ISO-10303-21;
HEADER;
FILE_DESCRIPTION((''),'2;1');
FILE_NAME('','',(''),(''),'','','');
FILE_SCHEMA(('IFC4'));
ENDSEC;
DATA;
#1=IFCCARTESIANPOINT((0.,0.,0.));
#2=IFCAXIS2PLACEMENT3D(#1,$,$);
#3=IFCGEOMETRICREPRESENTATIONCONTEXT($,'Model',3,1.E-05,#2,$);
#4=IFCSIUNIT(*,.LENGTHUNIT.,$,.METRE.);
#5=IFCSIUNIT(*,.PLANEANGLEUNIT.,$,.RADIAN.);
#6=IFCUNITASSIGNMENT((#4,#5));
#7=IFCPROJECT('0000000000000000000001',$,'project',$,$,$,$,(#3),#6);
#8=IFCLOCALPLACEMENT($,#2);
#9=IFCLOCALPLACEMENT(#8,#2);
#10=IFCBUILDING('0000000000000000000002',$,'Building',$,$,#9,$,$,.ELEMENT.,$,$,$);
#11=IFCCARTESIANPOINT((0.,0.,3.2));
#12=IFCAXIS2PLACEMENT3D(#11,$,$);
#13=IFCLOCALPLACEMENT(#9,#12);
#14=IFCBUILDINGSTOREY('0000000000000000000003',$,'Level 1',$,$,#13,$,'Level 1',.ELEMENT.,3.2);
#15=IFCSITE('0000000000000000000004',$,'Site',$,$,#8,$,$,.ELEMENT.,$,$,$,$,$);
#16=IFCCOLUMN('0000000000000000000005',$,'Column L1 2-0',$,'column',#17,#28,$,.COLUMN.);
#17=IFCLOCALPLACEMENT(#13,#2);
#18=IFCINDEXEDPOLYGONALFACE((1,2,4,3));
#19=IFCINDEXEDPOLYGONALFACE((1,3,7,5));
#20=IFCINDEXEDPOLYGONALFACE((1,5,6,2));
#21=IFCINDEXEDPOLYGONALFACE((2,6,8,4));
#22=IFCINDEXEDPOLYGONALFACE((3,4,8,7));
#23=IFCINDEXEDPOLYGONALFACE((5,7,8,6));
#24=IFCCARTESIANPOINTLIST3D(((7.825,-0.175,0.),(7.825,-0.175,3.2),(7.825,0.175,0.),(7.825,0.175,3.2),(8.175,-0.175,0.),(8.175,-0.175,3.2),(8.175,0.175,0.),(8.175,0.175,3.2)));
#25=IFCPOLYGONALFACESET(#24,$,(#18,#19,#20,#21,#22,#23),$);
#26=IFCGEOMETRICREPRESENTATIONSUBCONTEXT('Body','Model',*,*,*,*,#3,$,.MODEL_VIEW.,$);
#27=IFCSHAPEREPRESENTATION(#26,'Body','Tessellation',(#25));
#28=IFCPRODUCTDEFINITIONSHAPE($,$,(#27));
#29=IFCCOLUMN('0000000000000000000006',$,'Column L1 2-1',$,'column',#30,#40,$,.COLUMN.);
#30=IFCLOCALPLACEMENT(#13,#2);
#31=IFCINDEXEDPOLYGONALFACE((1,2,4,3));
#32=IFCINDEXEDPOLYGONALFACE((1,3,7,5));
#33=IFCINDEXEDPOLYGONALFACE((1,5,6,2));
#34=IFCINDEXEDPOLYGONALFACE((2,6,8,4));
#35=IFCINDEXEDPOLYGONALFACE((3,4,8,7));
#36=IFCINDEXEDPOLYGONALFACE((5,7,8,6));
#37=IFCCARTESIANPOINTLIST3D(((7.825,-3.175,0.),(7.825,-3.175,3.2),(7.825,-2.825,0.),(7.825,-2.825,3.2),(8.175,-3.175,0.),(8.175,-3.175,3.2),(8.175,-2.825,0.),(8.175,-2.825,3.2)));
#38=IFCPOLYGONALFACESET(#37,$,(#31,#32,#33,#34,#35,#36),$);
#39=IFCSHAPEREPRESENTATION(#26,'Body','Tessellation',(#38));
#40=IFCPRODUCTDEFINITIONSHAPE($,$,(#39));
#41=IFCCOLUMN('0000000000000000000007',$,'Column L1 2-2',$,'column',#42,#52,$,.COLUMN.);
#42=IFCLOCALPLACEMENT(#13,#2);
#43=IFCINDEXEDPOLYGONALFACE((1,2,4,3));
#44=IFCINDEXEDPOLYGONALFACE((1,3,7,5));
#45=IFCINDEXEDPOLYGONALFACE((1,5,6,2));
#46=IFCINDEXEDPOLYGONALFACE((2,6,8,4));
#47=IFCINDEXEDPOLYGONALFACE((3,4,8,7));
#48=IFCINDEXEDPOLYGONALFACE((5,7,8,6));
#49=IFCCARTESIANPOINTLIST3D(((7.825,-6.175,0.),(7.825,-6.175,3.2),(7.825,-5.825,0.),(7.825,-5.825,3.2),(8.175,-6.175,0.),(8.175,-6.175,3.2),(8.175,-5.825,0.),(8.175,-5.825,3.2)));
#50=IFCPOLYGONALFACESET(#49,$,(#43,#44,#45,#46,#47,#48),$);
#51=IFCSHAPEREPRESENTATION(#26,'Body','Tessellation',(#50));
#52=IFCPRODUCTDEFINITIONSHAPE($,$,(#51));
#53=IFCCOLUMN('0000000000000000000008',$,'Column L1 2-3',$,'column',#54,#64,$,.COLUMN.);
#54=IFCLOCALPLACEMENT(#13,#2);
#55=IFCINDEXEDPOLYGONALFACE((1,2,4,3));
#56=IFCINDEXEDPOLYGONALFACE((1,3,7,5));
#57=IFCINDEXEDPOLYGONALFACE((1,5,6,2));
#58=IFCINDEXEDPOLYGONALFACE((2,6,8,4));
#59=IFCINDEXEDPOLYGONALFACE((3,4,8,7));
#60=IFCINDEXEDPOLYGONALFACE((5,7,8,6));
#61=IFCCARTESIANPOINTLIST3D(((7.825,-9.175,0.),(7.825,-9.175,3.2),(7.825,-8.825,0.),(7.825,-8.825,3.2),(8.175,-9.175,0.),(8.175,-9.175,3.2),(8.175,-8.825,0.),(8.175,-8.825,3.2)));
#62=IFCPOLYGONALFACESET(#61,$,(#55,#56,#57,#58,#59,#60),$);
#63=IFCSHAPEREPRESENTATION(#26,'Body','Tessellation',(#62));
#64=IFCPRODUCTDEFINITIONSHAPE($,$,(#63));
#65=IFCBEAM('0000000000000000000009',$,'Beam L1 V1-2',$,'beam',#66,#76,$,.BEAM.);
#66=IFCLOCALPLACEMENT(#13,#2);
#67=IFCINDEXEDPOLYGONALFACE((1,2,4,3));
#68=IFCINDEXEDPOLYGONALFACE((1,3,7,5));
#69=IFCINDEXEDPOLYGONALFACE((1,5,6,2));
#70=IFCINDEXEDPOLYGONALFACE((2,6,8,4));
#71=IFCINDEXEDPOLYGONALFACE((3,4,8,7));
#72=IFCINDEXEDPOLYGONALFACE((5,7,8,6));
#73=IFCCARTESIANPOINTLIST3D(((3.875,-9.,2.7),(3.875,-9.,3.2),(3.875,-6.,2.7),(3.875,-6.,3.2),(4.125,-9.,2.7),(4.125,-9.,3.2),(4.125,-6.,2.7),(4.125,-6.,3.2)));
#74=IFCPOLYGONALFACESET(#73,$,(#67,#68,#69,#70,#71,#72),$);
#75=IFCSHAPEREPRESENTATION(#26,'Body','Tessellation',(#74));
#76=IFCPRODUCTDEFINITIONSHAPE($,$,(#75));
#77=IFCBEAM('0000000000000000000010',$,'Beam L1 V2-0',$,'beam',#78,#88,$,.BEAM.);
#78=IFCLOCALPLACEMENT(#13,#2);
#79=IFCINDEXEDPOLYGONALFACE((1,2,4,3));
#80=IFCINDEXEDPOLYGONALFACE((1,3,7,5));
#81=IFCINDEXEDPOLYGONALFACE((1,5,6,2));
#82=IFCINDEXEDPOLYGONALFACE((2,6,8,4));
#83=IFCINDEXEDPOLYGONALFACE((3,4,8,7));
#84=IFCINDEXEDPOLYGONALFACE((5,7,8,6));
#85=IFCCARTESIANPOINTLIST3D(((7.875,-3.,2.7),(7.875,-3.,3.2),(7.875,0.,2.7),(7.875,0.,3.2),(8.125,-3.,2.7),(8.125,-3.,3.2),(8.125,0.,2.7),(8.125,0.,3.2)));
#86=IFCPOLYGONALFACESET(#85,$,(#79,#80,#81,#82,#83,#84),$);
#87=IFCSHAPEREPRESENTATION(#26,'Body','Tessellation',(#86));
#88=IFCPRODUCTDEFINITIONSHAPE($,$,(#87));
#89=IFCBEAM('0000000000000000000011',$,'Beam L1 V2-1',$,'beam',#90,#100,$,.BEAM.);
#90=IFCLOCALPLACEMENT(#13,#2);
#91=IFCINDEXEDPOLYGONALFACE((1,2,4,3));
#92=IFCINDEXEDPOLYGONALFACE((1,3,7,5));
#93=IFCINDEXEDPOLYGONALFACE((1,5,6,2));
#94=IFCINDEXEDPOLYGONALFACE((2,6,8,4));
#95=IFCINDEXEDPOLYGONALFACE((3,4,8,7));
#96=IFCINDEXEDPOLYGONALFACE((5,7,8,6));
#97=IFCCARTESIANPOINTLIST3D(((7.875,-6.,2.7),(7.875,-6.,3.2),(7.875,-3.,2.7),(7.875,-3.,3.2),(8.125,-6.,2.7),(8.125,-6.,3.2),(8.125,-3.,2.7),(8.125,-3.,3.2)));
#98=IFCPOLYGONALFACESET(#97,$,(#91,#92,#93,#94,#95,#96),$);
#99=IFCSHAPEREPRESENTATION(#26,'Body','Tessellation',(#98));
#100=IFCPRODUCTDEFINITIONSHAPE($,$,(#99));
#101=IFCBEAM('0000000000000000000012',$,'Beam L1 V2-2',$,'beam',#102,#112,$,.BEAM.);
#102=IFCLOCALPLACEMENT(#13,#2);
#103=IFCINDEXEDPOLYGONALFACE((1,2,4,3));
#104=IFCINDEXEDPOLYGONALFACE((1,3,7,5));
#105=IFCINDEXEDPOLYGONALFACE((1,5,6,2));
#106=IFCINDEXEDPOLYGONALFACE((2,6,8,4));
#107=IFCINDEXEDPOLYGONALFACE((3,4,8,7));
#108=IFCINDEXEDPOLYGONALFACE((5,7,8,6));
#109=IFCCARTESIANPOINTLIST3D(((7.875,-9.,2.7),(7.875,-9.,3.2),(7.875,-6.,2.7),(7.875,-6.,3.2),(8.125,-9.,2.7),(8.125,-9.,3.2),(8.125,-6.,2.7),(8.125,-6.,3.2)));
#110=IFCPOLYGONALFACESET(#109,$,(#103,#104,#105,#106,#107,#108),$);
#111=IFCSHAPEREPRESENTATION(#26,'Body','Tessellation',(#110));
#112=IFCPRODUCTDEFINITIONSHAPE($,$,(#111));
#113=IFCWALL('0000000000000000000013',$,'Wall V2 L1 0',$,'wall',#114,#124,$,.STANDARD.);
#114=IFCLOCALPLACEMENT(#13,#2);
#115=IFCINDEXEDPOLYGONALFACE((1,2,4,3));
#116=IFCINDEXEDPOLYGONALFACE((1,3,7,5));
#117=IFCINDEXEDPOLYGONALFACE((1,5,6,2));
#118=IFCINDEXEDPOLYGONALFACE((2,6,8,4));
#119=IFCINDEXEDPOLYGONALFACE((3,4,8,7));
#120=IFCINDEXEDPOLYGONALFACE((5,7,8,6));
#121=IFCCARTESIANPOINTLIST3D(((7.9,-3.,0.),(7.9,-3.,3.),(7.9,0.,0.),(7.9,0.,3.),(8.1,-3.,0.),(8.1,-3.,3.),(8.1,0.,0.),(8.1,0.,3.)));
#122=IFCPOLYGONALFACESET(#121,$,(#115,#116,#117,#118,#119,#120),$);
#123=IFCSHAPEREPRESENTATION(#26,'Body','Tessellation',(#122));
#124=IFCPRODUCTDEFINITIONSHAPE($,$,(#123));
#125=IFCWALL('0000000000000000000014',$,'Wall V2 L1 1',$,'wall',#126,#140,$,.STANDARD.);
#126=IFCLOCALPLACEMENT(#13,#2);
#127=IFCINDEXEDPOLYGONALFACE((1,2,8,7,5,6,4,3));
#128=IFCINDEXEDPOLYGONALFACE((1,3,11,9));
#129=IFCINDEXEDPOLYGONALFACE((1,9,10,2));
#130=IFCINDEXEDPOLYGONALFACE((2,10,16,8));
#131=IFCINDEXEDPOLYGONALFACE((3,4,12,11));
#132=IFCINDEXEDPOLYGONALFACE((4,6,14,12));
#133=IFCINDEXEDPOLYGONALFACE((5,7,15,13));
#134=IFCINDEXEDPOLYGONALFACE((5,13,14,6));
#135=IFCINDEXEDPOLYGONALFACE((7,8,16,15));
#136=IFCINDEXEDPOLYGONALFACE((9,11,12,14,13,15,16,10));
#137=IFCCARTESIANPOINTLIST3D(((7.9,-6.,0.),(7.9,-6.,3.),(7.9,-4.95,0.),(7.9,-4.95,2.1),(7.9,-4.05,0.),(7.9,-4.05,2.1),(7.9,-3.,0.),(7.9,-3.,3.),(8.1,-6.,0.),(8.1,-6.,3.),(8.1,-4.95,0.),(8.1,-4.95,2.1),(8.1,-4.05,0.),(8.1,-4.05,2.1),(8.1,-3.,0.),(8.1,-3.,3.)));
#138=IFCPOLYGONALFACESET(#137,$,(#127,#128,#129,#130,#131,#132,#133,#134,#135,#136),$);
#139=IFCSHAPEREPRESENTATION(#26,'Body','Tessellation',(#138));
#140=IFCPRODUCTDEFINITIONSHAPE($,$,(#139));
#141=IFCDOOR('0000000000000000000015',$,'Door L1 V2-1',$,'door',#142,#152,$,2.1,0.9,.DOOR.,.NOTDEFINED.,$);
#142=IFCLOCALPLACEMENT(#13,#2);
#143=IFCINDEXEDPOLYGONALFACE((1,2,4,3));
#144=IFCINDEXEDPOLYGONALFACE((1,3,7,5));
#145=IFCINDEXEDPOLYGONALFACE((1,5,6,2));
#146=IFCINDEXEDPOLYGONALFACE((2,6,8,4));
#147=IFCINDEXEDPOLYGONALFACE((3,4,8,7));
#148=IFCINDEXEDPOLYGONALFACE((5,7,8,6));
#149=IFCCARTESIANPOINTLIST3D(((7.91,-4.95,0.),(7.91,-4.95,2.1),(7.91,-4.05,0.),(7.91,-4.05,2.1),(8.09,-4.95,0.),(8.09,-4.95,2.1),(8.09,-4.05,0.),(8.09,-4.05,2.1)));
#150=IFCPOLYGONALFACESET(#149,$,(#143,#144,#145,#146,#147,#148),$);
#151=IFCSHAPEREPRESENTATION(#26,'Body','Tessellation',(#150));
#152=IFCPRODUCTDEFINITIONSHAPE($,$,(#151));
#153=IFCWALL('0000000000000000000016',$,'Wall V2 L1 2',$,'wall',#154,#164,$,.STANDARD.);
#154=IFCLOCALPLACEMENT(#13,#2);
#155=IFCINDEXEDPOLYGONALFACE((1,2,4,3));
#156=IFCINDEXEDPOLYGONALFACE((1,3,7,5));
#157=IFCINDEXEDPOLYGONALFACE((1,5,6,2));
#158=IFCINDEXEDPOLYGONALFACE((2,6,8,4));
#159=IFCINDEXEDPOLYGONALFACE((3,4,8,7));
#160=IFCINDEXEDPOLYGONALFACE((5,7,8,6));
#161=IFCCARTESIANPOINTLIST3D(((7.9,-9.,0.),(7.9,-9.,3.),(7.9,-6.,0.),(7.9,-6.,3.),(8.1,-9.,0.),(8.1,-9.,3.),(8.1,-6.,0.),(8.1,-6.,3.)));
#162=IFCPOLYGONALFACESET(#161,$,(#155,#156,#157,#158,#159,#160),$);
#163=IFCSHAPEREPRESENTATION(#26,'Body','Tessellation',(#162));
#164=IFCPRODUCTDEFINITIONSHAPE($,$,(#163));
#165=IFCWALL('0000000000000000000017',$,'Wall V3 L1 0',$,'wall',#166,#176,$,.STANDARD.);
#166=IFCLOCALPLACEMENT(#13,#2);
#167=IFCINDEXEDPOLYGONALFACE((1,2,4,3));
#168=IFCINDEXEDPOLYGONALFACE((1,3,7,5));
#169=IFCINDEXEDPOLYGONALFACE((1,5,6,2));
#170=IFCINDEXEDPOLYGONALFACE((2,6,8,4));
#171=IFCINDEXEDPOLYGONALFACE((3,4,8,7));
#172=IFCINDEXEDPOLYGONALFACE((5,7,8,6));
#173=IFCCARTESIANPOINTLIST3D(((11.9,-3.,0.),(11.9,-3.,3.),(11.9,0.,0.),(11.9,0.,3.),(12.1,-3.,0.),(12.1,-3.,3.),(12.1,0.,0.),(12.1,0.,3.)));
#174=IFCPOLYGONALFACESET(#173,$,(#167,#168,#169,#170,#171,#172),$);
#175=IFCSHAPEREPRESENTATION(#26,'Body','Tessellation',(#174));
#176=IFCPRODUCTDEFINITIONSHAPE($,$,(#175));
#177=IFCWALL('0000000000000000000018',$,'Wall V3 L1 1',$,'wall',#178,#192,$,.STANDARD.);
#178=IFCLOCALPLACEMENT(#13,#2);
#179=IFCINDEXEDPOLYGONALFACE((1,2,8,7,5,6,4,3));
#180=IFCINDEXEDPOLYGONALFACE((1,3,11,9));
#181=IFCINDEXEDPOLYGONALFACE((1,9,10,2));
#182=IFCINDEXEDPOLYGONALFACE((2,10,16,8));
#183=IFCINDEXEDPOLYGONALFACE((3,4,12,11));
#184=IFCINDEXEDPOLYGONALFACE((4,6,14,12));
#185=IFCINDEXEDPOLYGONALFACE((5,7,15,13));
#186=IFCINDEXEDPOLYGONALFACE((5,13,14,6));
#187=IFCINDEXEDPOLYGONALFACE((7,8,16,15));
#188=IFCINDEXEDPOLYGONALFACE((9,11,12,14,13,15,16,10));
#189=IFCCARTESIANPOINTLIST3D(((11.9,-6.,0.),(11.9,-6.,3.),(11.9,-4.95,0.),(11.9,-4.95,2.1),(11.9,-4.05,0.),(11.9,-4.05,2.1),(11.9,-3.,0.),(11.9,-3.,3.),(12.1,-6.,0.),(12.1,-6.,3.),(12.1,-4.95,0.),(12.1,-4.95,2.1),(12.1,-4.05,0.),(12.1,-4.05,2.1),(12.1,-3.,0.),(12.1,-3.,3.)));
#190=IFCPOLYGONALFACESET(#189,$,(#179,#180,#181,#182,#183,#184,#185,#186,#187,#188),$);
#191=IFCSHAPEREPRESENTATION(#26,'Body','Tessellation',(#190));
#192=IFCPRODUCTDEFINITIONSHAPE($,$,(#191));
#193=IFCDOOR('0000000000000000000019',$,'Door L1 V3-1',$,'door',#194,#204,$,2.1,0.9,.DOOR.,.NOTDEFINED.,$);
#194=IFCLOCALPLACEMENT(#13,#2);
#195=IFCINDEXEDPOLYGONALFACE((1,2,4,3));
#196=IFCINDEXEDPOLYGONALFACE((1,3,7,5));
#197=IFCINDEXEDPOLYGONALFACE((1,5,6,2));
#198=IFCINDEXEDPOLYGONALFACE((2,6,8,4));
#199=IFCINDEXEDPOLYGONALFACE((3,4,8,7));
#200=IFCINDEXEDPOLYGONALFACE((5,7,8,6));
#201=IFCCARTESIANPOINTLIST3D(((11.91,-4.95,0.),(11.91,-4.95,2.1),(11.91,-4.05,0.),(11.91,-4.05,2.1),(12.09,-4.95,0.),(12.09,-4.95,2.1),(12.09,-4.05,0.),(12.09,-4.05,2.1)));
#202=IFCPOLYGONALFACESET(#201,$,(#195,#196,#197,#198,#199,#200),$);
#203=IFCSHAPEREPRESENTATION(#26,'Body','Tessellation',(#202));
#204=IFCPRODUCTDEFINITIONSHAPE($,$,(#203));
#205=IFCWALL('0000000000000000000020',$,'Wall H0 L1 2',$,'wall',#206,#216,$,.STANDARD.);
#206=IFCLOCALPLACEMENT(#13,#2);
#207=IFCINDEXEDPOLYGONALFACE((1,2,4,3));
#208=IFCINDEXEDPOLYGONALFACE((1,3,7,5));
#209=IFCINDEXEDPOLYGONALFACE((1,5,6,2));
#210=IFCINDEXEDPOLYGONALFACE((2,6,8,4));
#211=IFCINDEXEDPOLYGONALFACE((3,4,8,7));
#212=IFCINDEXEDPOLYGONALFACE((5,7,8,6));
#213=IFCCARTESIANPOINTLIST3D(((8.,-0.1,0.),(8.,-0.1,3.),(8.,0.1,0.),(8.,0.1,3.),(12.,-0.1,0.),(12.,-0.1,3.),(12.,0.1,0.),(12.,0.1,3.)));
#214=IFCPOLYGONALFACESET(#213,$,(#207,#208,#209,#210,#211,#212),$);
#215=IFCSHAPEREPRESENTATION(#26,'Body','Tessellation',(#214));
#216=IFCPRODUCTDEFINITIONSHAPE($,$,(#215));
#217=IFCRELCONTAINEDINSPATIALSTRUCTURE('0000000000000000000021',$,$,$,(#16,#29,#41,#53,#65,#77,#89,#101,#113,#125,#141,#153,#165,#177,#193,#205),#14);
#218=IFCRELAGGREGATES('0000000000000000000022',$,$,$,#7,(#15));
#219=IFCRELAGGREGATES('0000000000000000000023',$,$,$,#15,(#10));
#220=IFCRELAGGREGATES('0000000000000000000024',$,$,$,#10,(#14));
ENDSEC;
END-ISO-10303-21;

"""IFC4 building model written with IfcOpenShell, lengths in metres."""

from ifc_helpers import new_model, si_unit, frame, frame_2d, origin, origin_2d, place, context, subcontext, project, spatial, rectangle, extrude, element, fill, save


model = new_model("IFC4")

# Units and contexts
model_context = context("Model", 3, precision=1e-05, world=origin())
body_context = subcontext(model_context, "Body", "Model", "MODEL_VIEW")
ifc_project = project(units=[si_unit("LENGTHUNIT", "METRE"), si_unit("PLANEANGLEUNIT", "RADIAN")], contexts=[model_context])

# Site, building, storey
site_placement = place(None, origin())
site = spatial("IfcSite", under=ifc_project, at=site_placement, Name="Site", CompositionType="ELEMENT")
building_placement = place(site_placement, origin())
building = spatial("IfcBuilding", under=site, at=building_placement, Name="Building", CompositionType="ELEMENT")
storey_placement = place(building_placement, frame((0.0, 0.0, 3.2)))
storey = spatial("IfcBuildingStorey", under=building, at=storey_placement, Name="Level 1", LongName="Level 1", CompositionType="ELEMENT", Elevation=3.2)

# Columns
for number, where, name in (
    (1, (8.0, 0.0, 0.0), "Column L1 2-0"),
    (2, (8.0, -3.0, 0.0), "Column L1 2-1"),
    (3, (8.0, -6.0, 0.0), "Column L1 2-2"),
    (4, (8.0, -9.0, 0.0), "Column L1 2-3"),
):
    element("IfcColumn", number, at=place(storey_placement, frame(where)), inside=storey, Name=name, ObjectType="column", PredefinedType="COLUMN", context=body_context, shape_type="SweptSolid", body=[
        extrude(rectangle(XDim=0.35, YDim=0.35, at=origin_2d()), origin(), (0.0, 0.0, 1.0), 3.2),
    ])

# Beams
for number, where, z_axis, x_axis, name in (
    (5, (4.0, -6.0, 2.95), (0.0, -1.0, 0.0), (0.0, 0.0, 1.0), "Beam L1 V1-2"),
    (6, (8.0, 0.0, 2.95), (0.0, -1.0, 0.0), (0.0, 0.0, 1.0), "Beam L1 V2-0"),
    (7, (8.0, -3.0, 2.95), (0.0, -1.0, 0.0), (0.0, 0.0, 1.0), "Beam L1 V2-1"),
    (8, (8.0, -6.0, 2.95), (0.0, -1.0, 0.0), (0.0, 0.0, 1.0), "Beam L1 V2-2"),
):
    element("IfcBeam", number, at=place(storey_placement, frame(where, z_axis=z_axis, x_axis=x_axis)), inside=storey, Name=name, ObjectType="beam", PredefinedType="BEAM", context=body_context, shape_type="SweptSolid", body=[
        extrude(rectangle(XDim=0.5, YDim=0.25, at=origin_2d()), origin(), (0.0, 0.0, 1.0), 3.0),
    ])

# Wall
wall_1_placement = place(storey_placement, frame((8.0, 0.0, 0.0), z_axis=(0.0, 0.0, 1.0), x_axis=(0.0, -1.0, 0.0)))
element("IfcWall", 9, at=wall_1_placement, inside=storey, Name="Wall V2 L1 0", ObjectType="wall", PredefinedType="STANDARD", context=body_context, shape_type="SweptSolid", body=[
    extrude(rectangle(XDim=3.0, YDim=0.2, at=frame_2d((1.5, 0.0))), origin(), (0.0, 0.0, 1.0), 3.0),
])

# Wall, opening, door
wall_2_placement = place(storey_placement, frame((8.0, -3.0, 0.0), z_axis=(0.0, 0.0, 1.0), x_axis=(0.0, -1.0, 0.0)))
wall_2 = element("IfcWall", 10, at=wall_2_placement, inside=storey, Name="Wall V2 L1 1", ObjectType="wall", PredefinedType="STANDARD", context=body_context, shape_type="SweptSolid", body=[
    extrude(rectangle(XDim=3.0, YDim=0.2, at=frame_2d((1.5, 0.0))), origin(), (0.0, 0.0, 1.0), 3.0),
])
opening_1_placement = place(storey_placement, frame((8.0, -4.5, 0.0), z_axis=(0.0, 0.0, 1.0), x_axis=(0.0, -1.0, 0.0)))
opening_1 = element("IfcOpeningElement", 11, at=opening_1_placement, cuts=wall_2, ObjectType="Opening", PredefinedType="OPENING", context=body_context, shape_type="SweptSolid", body=[
    extrude(rectangle(XDim=0.9, YDim=0.22, at=origin_2d()), origin(), (0.0, 0.0, 1.0), 2.1),
])
door_1_placement = place(storey_placement, frame((8.0, -4.5, 0.0), z_axis=(0.0, 0.0, 1.0), x_axis=(0.0, -1.0, 0.0)))
door_1 = element("IfcDoor", 12, at=door_1_placement, inside=storey, Name="Door L1 V2-1", ObjectType="door", OperationType="NOTDEFINED", OverallHeight=2.1, OverallWidth=0.9, PredefinedType="DOOR", context=body_context, shape_type="SweptSolid", body=[
    extrude(rectangle(XDim=0.9, YDim=0.18, at=origin_2d()), origin(), (0.0, 0.0, 1.0), 2.1),
])
fill(opening_1, door_1)

# Walls
for number, where, z_axis, x_axis, name in (
    (13, (8.0, -6.0, 0.0), (0.0, 0.0, 1.0), (0.0, -1.0, 0.0), "Wall V2 L1 2"),
    (14, (12.0, 0.0, 0.0), (0.0, 0.0, 1.0), (0.0, -1.0, 0.0), "Wall V3 L1 0"),
):
    element("IfcWall", number, at=place(storey_placement, frame(where, z_axis=z_axis, x_axis=x_axis)), inside=storey, Name=name, ObjectType="wall", PredefinedType="STANDARD", context=body_context, shape_type="SweptSolid", body=[
        extrude(rectangle(XDim=3.0, YDim=0.2, at=frame_2d((1.5, 0.0))), origin(), (0.0, 0.0, 1.0), 3.0),
    ])

# Wall, opening, door
wall_3_placement = place(storey_placement, frame((12.0, -3.0, 0.0), z_axis=(0.0, 0.0, 1.0), x_axis=(0.0, -1.0, 0.0)))
wall_3 = element("IfcWall", 15, at=wall_3_placement, inside=storey, Name="Wall V3 L1 1", ObjectType="wall", PredefinedType="STANDARD", context=body_context, shape_type="SweptSolid", body=[
    extrude(rectangle(XDim=3.0, YDim=0.2, at=frame_2d((1.5, 0.0))), origin(), (0.0, 0.0, 1.0), 3.0),
])
opening_2_placement = place(storey_placement, frame((12.0, -4.5, 0.0), z_axis=(0.0, 0.0, 1.0), x_axis=(0.0, -1.0, 0.0)))
opening_2 = element("IfcOpeningElement", 16, at=opening_2_placement, cuts=wall_3, ObjectType="Opening", PredefinedType="OPENING", context=body_context, shape_type="SweptSolid", body=[
    extrude(rectangle(XDim=0.9, YDim=0.22, at=origin_2d()), origin(), (0.0, 0.0, 1.0), 2.1),
])
door_2_placement = place(storey_placement, frame((12.0, -4.5, 0.0), z_axis=(0.0, 0.0, 1.0), x_axis=(0.0, -1.0, 0.0)))
door_2 = element("IfcDoor", 17, at=door_2_placement, inside=storey, Name="Door L1 V3-1", ObjectType="door", OperationType="NOTDEFINED", OverallHeight=2.1, OverallWidth=0.9, PredefinedType="DOOR", context=body_context, shape_type="SweptSolid", body=[
    extrude(rectangle(XDim=0.9, YDim=0.18, at=origin_2d()), origin(), (0.0, 0.0, 1.0), 2.1),
])
fill(opening_2, door_2)

# Wall
wall_4_placement = place(storey_placement, frame((8.0, 0.0, 0.0), z_axis=(0.0, 0.0, 1.0), x_axis=(1.0, 0.0, 0.0)))
element("IfcWall", 18, at=wall_4_placement, inside=storey, Name="Wall H0 L1 2", ObjectType="wall", PredefinedType="STANDARD", context=body_context, shape_type="SweptSolid", body=[
    extrude(rectangle(XDim=4.0, YDim=0.2, at=frame_2d((2.0, 0.0))), origin(), (0.0, 0.0, 1.0), 3.0),
])

save(model, "model.ifc")
